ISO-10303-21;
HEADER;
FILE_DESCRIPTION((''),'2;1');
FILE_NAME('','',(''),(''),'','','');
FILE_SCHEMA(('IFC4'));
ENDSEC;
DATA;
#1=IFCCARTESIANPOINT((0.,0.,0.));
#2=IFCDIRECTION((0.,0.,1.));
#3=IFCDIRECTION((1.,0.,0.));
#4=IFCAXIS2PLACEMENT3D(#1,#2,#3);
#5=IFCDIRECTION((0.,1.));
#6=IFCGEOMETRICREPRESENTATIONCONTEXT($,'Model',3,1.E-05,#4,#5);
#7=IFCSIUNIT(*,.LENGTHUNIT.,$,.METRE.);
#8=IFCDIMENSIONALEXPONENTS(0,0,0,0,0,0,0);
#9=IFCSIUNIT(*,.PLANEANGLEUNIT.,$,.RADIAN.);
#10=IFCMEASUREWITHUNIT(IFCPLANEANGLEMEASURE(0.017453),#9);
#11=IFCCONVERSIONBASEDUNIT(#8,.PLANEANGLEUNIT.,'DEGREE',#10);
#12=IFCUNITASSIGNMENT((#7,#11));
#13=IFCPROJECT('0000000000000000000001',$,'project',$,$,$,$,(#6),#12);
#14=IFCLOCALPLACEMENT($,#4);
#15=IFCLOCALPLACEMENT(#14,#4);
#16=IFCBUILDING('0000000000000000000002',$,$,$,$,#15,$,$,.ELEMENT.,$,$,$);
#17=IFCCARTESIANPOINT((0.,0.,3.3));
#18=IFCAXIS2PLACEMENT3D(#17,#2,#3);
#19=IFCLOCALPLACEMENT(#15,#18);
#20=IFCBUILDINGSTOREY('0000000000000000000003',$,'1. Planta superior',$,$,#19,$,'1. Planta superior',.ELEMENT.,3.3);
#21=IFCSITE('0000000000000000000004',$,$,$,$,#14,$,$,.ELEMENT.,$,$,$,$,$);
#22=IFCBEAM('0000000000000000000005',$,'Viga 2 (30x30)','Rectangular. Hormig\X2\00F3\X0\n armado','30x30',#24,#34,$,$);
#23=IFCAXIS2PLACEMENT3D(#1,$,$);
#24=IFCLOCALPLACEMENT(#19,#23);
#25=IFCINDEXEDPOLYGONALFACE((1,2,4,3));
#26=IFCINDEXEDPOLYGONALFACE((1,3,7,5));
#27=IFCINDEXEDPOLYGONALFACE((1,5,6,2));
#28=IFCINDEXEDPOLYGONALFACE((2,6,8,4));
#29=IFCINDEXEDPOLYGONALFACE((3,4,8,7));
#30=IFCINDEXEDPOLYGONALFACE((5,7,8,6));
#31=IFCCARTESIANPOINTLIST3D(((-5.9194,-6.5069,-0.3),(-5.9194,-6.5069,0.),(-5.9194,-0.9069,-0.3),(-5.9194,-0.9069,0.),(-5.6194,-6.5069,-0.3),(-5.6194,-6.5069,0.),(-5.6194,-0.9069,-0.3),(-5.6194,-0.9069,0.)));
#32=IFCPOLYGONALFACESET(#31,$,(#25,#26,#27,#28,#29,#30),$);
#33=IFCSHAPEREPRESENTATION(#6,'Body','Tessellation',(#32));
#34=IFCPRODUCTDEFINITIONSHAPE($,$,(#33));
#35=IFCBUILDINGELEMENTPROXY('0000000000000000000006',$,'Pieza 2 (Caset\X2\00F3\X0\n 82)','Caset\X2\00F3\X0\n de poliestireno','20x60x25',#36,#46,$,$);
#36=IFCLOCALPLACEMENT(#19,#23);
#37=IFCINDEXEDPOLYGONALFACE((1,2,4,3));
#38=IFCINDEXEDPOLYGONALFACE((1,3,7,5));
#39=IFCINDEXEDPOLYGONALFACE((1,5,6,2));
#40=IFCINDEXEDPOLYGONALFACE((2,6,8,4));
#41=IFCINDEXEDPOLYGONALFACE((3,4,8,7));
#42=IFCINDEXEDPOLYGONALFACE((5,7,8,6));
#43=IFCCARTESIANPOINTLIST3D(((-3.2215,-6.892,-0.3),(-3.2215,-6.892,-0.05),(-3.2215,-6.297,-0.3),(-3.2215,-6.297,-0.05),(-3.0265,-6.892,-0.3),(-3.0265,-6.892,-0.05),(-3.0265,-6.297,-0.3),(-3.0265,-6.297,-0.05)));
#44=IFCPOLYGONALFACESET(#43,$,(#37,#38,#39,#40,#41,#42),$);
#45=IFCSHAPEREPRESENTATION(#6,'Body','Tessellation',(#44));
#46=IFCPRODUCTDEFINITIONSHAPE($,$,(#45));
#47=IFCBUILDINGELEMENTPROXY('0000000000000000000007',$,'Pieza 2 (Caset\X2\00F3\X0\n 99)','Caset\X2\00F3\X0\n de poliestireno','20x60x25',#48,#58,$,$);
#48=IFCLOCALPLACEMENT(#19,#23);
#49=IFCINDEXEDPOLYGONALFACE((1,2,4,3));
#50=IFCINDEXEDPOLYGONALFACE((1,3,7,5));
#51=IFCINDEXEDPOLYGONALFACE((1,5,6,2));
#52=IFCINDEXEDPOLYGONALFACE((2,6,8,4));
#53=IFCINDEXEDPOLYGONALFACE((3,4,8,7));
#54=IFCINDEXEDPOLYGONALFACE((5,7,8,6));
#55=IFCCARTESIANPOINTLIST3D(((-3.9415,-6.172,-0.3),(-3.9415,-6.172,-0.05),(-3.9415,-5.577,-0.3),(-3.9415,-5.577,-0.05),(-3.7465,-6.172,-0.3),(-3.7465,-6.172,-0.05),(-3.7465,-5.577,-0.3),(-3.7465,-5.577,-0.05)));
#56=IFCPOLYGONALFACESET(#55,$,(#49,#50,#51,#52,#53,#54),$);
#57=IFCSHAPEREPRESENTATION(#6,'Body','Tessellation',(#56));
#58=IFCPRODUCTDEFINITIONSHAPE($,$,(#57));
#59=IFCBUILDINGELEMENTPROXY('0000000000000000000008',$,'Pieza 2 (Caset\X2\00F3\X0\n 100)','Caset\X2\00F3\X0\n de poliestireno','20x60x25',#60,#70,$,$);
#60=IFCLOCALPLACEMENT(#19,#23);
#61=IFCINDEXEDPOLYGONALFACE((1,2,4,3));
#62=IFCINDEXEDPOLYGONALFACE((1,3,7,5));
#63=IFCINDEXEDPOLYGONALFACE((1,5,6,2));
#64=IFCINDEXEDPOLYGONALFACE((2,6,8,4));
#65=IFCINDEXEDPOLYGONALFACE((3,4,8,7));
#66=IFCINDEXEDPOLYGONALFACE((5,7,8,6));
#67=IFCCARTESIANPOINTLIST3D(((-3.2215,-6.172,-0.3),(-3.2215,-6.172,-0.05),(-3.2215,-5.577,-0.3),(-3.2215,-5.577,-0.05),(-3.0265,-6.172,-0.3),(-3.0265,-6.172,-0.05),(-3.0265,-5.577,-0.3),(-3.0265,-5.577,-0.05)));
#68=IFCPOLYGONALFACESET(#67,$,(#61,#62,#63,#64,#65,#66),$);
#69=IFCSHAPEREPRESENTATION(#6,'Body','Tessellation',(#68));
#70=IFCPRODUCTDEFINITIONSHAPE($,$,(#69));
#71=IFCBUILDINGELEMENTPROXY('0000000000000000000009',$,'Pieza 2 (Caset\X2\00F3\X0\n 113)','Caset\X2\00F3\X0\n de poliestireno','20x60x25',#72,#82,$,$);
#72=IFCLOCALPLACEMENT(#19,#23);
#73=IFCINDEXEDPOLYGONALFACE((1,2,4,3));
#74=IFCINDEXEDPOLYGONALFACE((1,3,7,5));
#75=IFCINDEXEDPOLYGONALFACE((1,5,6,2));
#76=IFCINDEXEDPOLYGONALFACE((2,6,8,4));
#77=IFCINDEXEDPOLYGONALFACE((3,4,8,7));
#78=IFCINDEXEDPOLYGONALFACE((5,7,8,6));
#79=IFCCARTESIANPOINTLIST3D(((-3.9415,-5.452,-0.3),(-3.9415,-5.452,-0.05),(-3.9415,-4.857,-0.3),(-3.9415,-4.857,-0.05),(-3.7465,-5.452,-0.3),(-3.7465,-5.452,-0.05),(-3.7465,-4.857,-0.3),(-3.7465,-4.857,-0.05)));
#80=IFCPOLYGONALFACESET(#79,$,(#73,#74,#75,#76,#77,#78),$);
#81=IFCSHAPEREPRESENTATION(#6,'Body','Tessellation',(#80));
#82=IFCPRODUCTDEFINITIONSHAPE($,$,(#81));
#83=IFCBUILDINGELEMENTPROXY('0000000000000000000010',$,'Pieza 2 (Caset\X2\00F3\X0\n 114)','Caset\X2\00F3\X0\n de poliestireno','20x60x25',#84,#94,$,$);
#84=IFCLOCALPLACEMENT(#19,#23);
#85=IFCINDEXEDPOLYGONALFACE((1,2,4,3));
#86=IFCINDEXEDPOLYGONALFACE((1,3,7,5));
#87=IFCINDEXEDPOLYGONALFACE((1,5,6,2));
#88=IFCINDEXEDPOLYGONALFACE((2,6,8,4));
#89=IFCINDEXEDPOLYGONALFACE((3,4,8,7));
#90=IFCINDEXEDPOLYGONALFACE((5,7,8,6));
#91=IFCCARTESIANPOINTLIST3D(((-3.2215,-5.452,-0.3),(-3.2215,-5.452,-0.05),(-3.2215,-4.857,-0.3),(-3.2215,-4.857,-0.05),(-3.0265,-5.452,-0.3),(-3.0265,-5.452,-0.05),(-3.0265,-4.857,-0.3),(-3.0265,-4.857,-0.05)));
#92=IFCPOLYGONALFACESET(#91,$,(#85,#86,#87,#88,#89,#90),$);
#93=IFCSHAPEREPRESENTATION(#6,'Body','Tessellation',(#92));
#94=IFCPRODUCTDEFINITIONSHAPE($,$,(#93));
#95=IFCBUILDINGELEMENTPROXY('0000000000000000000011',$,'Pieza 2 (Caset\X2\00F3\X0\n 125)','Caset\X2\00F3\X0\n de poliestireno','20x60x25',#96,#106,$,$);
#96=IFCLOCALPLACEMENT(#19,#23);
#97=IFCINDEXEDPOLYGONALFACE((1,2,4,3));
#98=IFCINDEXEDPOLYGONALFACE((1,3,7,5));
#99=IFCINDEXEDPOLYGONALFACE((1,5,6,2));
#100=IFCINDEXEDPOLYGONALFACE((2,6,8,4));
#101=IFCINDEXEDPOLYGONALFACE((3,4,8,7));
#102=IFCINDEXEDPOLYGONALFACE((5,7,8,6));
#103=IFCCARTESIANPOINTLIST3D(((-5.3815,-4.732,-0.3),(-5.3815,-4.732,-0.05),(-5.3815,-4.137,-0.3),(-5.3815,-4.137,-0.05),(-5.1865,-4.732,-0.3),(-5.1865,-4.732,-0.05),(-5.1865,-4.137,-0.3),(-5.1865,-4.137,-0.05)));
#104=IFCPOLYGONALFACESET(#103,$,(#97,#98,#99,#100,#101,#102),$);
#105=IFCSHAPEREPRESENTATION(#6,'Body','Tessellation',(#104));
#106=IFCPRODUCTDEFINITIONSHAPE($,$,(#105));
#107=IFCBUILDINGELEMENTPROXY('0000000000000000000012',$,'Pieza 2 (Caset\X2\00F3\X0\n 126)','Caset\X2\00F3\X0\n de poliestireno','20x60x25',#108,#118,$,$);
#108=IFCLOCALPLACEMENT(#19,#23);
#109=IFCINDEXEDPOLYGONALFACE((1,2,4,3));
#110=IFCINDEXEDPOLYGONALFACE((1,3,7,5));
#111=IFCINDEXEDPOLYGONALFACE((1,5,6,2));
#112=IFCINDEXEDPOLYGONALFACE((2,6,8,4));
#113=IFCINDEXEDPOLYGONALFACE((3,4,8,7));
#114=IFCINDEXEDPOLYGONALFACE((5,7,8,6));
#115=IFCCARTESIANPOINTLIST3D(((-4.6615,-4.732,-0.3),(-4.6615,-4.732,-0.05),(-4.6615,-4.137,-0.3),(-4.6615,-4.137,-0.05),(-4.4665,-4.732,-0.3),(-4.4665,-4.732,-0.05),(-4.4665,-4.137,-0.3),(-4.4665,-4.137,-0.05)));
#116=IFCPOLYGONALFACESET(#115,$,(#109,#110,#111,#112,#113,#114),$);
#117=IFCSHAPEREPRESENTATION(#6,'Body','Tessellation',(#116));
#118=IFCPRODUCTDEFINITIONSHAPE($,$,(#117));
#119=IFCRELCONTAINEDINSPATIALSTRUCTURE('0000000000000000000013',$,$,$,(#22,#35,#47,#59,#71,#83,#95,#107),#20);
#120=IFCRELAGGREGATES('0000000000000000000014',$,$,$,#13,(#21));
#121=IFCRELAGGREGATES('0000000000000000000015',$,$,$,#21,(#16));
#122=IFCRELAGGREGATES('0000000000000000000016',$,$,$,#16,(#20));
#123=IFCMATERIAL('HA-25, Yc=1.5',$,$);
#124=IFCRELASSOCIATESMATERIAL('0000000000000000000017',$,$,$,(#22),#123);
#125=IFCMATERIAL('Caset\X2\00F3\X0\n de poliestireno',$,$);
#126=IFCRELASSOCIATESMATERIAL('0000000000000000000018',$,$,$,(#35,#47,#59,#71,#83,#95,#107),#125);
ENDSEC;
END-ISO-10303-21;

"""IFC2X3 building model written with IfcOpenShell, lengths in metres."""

from ifc_helpers import new_model, entity, si_unit, converted_unit, direction, frame, frame_2d, origin_with_axes, origin_2d_with_axis, place, context, project, spatial, rectangle, extrude, source, transform, mapped, material, element, save


model = new_model("IFC2X3")

# Units and contexts
model_context = context("Model", 3, precision=1e-05, world=origin_with_axes(), true_north=direction((0.0, 1.0)))
ifc_project = project(units=[si_unit("LENGTHUNIT", "METRE"), converted_unit("PLANEANGLEUNIT", "DEGREE", entity("IfcPlaneAngleMeasure", 0.017453), si_unit("PLANEANGLEUNIT", "RADIAN"), dimensions=[0, 0, 0, 0, 0, 0, 0])], contexts=[model_context])

# Site, building, storey
site_placement = place(None, origin_with_axes())
site = spatial("IfcSite", under=ifc_project, at=site_placement, CompositionType="ELEMENT")
building_placement = place(site_placement, origin_with_axes())
building = spatial("IfcBuilding", under=site, at=building_placement, CompositionType="ELEMENT")
storey_placement = place(building_placement, frame((0.0, 0.0, 3.3), z_axis=(0.0, 0.0, 1.0), x_axis=(1.0, 0.0, 0.0)))
storey = spatial("IfcBuildingStorey", under=building, at=storey_placement, Name="1. Planta superior", LongName="1. Planta superior", CompositionType="ELEMENT", Elevation=3.3)

# Beam
ifc_material_1 = material(Name="HA-25, Yc=1.5")
beam_placement = place(storey_placement, frame((-5.7694, -6.5069, 0.0), z_axis=(0.0, 1.0, 0.0), x_axis=(-1.0, 0.0, 0.0)))
element("IfcBeam", 1, at=beam_placement, inside=storey, material=ifc_material_1, Name="Viga 2 (30x30)", Description="Rectangular. Hormigón armado", ObjectType="30x30", context=model_context, shape_type="SweptSolid", body=[
    extrude(rectangle(XDim=0.3, YDim=0.3, at=frame_2d((0.0, -0.15), x_axis=(1.0, 0.0))), origin_with_axes(), (0.0, 0.0, 1.0), 5.6),
])

# Building element proxies
ifc_material_2 = material(Name="Casetón de poliestireno")
shared_shape = source(origin_with_axes(), model_context, "Body", "SweptSolid", [
    extrude(rectangle(XDim=0.195, YDim=0.25, at=origin_2d_with_axis()), origin_with_axes(), (0.0, 0.0, 1.0), 0.595),
])
placement_1 = place(storey_placement, frame((-3.124, -6.892, -0.175), z_axis=(0.0, 1.0, 0.0), x_axis=(-1.0, 0.0, 0.0)))
proxy_placement = place(placement_1, origin_with_axes())
element("IfcBuildingElementProxy", 2, at=proxy_placement, inside=storey, material=ifc_material_2, Name="Pieza 2 (Casetón 82)", Description="Casetón de poliestireno", ObjectType="20x60x25", context=model_context, shape_type="MappedRepresentation", body=[
    mapped(shared_shape, transform((0.0, 0.0, 0.0), x_axis=(1.0, 0.0, 0.0), y_axis=(0.0, 1.0, 0.0), z_axis=(0.0, 0.0, 1.0))),
])
placement_2 = place(storey_placement, frame((-3.844, -6.172, -0.175), z_axis=(0.0, 1.0, 0.0), x_axis=(-1.0, 0.0, 0.0)))
for number, where, z_axis, x_axis, name in (
    (3, (0.0, 0.0, 0.0), (0.0, 0.0, 1.0), (1.0, 0.0, 0.0), "Pieza 2 (Casetón 99)"),
):
    element("IfcBuildingElementProxy", number, at=place(placement_2, frame(where, z_axis=z_axis, x_axis=x_axis)), inside=storey, material=ifc_material_2, Name=name, Description="Casetón de poliestireno", ObjectType="20x60x25", context=model_context, shape_type="MappedRepresentation", body=[
        mapped(shared_shape, transform((0.0, 0.0, 0.0), x_axis=(1.0, 0.0, 0.0), y_axis=(0.0, 1.0, 0.0), z_axis=(0.0, 0.0, 1.0))),
    ])
placement_3 = place(storey_placement, frame((-3.124, -6.172, -0.175), z_axis=(0.0, 1.0, 0.0), x_axis=(-1.0, 0.0, 0.0)))
for number, where, z_axis, x_axis, name in (
    (4, (0.0, 0.0, 0.0), (0.0, 0.0, 1.0), (1.0, 0.0, 0.0), "Pieza 2 (Casetón 100)"),
):
    element("IfcBuildingElementProxy", number, at=place(placement_3, frame(where, z_axis=z_axis, x_axis=x_axis)), inside=storey, material=ifc_material_2, Name=name, Description="Casetón de poliestireno", ObjectType="20x60x25", context=model_context, shape_type="MappedRepresentation", body=[
        mapped(shared_shape, transform((0.0, 0.0, 0.0), x_axis=(1.0, 0.0, 0.0), y_axis=(0.0, 1.0, 0.0), z_axis=(0.0, 0.0, 1.0))),
    ])
placement_4 = place(storey_placement, frame((-3.844, -5.452, -0.175), z_axis=(0.0, 1.0, 0.0), x_axis=(-1.0, 0.0, 0.0)))
for number, where, z_axis, x_axis, name in (
    (5, (0.0, 0.0, 0.0), (0.0, 0.0, 1.0), (1.0, 0.0, 0.0), "Pieza 2 (Casetón 113)"),
):
    element("IfcBuildingElementProxy", number, at=place(placement_4, frame(where, z_axis=z_axis, x_axis=x_axis)), inside=storey, material=ifc_material_2, Name=name, Description="Casetón de poliestireno", ObjectType="20x60x25", context=model_context, shape_type="MappedRepresentation", body=[
        mapped(shared_shape, transform((0.0, 0.0, 0.0), x_axis=(1.0, 0.0, 0.0), y_axis=(0.0, 1.0, 0.0), z_axis=(0.0, 0.0, 1.0))),
    ])
placement_5 = place(storey_placement, frame((-3.124, -5.452, -0.175), z_axis=(0.0, 1.0, 0.0), x_axis=(-1.0, 0.0, 0.0)))
for number, where, z_axis, x_axis, name in (
    (6, (0.0, 0.0, 0.0), (0.0, 0.0, 1.0), (1.0, 0.0, 0.0), "Pieza 2 (Casetón 114)"),
):
    element("IfcBuildingElementProxy", number, at=place(placement_5, frame(where, z_axis=z_axis, x_axis=x_axis)), inside=storey, material=ifc_material_2, Name=name, Description="Casetón de poliestireno", ObjectType="20x60x25", context=model_context, shape_type="MappedRepresentation", body=[
        mapped(shared_shape, transform((0.0, 0.0, 0.0), x_axis=(1.0, 0.0, 0.0), y_axis=(0.0, 1.0, 0.0), z_axis=(0.0, 0.0, 1.0))),
    ])
placement_6 = place(storey_placement, frame((-5.284, -4.732, -0.175), z_axis=(0.0, 1.0, 0.0), x_axis=(-1.0, 0.0, 0.0)))
for number, where, z_axis, x_axis, name in (
    (7, (0.0, 0.0, 0.0), (0.0, 0.0, 1.0), (1.0, 0.0, 0.0), "Pieza 2 (Casetón 125)"),
):
    element("IfcBuildingElementProxy", number, at=place(placement_6, frame(where, z_axis=z_axis, x_axis=x_axis)), inside=storey, material=ifc_material_2, Name=name, Description="Casetón de poliestireno", ObjectType="20x60x25", context=model_context, shape_type="MappedRepresentation", body=[
        mapped(shared_shape, transform((0.0, 0.0, 0.0), x_axis=(1.0, 0.0, 0.0), y_axis=(0.0, 1.0, 0.0), z_axis=(0.0, 0.0, 1.0))),
    ])
placement_7 = place(storey_placement, frame((-4.564, -4.732, -0.175), z_axis=(0.0, 1.0, 0.0), x_axis=(-1.0, 0.0, 0.0)))
for number, where, z_axis, x_axis, name in (
    (8, (0.0, 0.0, 0.0), (0.0, 0.0, 1.0), (1.0, 0.0, 0.0), "Pieza 2 (Casetón 126)"),
):
    element("IfcBuildingElementProxy", number, at=place(placement_7, frame(where, z_axis=z_axis, x_axis=x_axis)), inside=storey, material=ifc_material_2, Name=name, Description="Casetón de poliestireno", ObjectType="20x60x25", context=model_context, shape_type="MappedRepresentation", body=[
        mapped(shared_shape, transform((0.0, 0.0, 0.0), x_axis=(1.0, 0.0, 0.0), y_axis=(0.0, 1.0, 0.0), z_axis=(0.0, 0.0, 1.0))),
    ])

save(model, "model.ifc")
